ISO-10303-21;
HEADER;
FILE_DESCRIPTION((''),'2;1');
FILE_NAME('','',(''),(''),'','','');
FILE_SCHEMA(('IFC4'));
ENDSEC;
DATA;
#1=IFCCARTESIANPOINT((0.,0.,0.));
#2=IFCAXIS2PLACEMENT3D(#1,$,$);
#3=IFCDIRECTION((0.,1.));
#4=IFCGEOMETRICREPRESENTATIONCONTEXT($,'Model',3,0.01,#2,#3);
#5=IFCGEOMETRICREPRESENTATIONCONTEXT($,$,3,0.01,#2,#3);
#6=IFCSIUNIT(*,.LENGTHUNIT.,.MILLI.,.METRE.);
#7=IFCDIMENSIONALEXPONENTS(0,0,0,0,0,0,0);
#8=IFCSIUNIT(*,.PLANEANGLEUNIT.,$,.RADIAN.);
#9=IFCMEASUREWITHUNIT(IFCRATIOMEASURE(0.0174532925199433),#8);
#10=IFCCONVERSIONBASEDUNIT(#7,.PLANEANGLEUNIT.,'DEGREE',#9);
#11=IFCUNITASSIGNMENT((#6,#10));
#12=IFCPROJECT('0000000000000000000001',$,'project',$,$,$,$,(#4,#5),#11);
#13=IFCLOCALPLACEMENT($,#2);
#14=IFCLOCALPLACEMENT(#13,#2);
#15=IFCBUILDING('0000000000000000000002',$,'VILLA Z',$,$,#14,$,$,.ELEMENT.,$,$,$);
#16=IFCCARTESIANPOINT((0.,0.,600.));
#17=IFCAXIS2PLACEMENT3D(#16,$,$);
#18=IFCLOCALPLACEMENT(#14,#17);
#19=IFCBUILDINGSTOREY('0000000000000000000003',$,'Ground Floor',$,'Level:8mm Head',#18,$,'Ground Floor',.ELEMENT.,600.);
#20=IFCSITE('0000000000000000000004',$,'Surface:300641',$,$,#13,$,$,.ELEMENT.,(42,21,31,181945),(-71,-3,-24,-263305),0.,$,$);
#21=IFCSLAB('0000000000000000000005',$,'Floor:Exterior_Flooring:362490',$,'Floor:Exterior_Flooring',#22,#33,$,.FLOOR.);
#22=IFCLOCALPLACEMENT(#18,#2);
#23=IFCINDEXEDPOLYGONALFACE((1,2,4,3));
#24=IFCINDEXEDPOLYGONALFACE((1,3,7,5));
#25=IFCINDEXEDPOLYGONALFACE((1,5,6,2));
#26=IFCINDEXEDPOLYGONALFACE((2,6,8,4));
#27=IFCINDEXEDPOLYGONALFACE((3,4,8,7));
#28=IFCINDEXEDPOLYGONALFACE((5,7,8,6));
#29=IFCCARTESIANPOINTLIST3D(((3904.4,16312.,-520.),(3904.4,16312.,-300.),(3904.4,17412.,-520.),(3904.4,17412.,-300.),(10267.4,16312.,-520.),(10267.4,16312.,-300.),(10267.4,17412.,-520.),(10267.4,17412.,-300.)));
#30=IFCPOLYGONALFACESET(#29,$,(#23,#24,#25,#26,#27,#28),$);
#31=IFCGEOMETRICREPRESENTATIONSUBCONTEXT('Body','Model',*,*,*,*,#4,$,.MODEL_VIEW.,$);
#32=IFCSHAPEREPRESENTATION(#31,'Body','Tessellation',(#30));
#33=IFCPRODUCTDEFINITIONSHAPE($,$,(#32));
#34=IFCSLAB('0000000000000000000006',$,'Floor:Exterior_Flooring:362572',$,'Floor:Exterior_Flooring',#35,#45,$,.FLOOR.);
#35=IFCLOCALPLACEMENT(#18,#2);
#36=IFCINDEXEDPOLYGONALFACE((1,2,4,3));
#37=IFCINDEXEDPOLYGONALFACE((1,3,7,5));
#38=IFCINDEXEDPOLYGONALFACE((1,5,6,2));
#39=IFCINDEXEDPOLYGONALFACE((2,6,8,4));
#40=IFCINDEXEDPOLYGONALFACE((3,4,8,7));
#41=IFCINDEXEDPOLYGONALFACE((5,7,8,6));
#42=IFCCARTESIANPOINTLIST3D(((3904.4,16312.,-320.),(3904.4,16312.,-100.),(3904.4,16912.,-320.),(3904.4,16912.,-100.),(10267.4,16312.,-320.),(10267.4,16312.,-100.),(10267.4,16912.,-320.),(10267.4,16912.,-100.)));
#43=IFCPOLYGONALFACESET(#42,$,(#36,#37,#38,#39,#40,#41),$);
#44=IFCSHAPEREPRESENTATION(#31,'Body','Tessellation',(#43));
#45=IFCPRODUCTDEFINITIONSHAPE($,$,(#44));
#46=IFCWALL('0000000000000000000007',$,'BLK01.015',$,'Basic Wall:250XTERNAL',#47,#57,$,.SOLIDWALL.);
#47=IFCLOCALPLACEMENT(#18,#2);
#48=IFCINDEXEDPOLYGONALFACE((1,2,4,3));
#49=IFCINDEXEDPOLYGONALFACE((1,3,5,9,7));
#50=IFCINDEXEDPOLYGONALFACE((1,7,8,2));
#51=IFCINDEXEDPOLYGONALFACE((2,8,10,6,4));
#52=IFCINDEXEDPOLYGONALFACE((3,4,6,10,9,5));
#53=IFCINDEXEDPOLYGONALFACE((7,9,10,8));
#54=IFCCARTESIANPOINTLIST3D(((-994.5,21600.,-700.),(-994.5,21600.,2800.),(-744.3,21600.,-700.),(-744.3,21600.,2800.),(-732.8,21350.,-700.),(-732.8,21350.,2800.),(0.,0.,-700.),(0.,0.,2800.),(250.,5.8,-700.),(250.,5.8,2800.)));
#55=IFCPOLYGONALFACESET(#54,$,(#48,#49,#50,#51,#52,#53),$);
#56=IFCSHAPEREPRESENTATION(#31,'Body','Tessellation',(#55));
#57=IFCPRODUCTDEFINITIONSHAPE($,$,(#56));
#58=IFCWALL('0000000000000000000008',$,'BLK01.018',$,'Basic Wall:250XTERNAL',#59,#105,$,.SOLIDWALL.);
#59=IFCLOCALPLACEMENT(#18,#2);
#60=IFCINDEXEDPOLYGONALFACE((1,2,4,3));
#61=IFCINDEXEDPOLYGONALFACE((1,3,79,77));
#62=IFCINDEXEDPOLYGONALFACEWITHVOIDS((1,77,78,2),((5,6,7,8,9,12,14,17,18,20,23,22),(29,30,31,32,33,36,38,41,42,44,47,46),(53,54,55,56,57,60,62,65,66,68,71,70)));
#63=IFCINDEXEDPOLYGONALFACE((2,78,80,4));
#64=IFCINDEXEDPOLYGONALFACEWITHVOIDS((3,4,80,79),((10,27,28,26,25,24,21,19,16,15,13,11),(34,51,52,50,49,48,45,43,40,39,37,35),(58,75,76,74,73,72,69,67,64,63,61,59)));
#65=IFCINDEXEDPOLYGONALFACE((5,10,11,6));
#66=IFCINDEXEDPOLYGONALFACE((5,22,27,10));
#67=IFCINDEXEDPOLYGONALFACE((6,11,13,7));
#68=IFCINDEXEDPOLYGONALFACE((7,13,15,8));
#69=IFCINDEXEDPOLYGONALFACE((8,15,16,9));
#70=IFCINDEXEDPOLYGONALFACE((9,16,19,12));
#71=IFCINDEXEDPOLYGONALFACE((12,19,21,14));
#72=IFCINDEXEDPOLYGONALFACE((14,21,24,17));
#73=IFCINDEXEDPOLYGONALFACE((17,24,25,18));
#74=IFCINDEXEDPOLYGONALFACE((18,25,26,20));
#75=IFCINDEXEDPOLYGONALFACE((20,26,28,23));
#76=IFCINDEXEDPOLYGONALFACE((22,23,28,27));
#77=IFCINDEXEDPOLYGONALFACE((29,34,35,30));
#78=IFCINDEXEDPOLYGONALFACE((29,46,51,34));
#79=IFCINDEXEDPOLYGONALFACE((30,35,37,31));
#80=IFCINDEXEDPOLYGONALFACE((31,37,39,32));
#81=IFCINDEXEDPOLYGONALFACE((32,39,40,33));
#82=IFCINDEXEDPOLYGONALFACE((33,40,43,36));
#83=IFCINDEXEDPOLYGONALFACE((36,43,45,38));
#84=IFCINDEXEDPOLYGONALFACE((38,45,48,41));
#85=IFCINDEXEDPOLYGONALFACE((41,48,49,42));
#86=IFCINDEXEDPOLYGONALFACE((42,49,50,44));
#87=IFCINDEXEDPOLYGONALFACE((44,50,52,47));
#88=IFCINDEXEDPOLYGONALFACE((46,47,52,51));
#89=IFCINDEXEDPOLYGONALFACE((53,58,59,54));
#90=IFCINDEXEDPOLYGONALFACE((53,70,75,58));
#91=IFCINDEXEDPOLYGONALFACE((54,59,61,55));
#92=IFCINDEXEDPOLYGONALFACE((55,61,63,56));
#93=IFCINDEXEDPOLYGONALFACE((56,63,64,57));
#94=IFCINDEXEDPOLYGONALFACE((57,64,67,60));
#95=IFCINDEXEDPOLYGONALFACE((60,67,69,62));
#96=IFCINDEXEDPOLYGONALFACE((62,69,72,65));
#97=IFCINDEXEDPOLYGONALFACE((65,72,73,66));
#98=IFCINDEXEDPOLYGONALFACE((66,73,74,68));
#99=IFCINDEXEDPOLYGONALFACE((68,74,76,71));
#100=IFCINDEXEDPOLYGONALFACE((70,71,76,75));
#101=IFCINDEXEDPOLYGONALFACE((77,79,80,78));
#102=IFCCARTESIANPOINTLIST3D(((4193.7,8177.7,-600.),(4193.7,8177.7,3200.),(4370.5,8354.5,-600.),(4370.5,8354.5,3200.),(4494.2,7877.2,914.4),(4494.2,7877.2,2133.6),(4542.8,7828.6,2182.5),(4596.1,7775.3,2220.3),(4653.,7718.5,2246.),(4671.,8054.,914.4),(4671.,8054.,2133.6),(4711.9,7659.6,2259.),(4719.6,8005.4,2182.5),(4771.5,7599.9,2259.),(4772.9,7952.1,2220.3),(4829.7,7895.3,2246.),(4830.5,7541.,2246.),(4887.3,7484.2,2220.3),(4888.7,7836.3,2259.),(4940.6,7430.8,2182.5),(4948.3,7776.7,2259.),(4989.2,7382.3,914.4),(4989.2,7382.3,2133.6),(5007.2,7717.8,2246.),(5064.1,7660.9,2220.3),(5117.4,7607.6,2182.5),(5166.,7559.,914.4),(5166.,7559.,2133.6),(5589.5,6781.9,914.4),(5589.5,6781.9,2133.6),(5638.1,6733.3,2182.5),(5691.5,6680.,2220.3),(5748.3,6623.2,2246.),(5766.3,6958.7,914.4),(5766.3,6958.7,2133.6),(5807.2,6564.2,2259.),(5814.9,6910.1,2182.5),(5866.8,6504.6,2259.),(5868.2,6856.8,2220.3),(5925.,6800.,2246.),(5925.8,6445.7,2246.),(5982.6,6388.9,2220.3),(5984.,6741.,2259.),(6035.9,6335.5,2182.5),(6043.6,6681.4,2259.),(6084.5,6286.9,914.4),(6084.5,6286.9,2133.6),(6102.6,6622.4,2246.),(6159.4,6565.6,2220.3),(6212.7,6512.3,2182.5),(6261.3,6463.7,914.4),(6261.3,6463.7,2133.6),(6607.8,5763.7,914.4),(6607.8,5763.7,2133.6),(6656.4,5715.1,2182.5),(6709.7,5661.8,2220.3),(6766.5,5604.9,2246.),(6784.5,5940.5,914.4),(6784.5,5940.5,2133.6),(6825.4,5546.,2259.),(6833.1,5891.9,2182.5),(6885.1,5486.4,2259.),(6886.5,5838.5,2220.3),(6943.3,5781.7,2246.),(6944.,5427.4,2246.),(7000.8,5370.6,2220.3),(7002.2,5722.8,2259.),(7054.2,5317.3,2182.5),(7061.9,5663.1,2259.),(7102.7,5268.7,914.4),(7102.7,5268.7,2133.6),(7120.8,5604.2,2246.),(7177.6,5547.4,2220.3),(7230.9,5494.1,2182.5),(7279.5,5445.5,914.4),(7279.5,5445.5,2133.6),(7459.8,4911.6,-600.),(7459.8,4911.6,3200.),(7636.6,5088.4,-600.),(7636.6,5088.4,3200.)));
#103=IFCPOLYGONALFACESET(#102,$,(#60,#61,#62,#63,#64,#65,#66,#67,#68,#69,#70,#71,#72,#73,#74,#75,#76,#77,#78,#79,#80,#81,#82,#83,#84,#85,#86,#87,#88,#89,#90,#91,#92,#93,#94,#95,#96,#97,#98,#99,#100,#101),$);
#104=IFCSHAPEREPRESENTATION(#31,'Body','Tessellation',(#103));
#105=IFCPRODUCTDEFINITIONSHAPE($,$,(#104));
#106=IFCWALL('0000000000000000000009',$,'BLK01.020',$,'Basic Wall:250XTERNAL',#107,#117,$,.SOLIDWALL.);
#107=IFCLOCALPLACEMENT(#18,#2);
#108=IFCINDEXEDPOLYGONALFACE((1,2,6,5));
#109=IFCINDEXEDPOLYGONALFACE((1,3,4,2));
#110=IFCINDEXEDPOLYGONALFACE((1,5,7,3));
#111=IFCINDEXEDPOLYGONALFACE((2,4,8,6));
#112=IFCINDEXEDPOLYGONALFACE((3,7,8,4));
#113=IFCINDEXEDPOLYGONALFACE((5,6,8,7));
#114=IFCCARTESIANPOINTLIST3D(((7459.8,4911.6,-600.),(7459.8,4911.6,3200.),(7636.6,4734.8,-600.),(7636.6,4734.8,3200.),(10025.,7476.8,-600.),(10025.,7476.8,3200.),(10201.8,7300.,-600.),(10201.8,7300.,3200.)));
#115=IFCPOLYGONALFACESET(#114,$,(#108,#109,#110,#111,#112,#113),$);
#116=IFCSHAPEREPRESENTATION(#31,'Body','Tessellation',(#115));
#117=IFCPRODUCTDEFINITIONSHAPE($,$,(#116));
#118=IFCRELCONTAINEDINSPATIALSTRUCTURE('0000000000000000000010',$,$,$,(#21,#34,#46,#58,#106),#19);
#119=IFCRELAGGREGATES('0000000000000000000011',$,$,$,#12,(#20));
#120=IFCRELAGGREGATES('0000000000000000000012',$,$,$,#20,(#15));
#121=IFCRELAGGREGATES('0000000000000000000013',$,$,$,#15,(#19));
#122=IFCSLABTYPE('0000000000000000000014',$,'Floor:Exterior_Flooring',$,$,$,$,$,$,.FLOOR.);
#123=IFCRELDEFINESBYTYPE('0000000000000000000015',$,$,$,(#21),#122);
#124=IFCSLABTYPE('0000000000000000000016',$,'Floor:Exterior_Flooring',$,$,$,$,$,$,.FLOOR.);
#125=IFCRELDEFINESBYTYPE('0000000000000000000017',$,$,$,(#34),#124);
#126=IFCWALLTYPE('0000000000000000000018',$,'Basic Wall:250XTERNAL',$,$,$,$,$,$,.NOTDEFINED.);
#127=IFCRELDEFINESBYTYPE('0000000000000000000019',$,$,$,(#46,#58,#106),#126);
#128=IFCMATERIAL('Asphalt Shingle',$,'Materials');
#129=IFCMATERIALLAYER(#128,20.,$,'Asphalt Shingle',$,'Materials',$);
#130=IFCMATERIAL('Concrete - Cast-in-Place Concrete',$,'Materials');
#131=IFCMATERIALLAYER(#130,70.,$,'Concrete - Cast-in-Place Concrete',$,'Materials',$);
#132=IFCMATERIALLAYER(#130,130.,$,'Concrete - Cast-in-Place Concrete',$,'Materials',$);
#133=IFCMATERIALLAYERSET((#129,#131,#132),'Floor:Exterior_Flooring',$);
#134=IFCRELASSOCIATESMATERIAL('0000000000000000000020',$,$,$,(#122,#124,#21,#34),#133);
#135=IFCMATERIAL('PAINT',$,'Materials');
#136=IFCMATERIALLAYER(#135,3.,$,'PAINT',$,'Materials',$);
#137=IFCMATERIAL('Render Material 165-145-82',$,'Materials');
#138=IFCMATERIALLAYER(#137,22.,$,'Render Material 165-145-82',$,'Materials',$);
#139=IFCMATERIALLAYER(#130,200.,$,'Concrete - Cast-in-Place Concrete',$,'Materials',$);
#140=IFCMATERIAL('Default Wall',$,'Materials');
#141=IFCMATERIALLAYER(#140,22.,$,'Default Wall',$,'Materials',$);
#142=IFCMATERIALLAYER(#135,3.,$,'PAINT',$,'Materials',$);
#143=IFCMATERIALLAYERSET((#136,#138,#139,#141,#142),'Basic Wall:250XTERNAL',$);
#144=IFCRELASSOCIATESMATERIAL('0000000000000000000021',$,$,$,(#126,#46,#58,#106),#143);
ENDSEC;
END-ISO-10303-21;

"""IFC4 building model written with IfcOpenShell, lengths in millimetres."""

from ifc_helpers import new_model, entity, si_unit, converted_unit, direction, frame, frame_2d, origin, origin_2d_with_axis, place, context, subcontext, project, spatial, polyline, circle_curve, parameter, trimmed, segment, composite_curve, rectangle, outline, extrude, clip, halfspace, material, layer, layer_set, layer_usage, type_object, element, save


model = new_model("IFC4")

# Units and contexts
model_context = context("Model", 3, precision=0.01, world=origin(), true_north=direction((0.0, 1.0)))
context_of_model = context(None, 3, precision=0.01, world=origin(), true_north=direction((0.0, 1.0)))
body_context = subcontext(model_context, "Body", "Model", "MODEL_VIEW")
ifc_project = project(units=[si_unit("LENGTHUNIT", "METRE", prefix="MILLI"), converted_unit("PLANEANGLEUNIT", "DEGREE", entity("IfcRatioMeasure", 0.0174532925199433), si_unit("PLANEANGLEUNIT", "RADIAN"), dimensions=[0, 0, 0, 0, 0, 0, 0])], contexts=[model_context, context_of_model])

# Site, building, storey
site_placement = place(None, origin())
site = spatial("IfcSite", under=ifc_project, at=site_placement, Name="Surface:300641", CompositionType="ELEMENT", RefLatitude=(42, 21, 31, 181945), RefLongitude=(-71, -3, -24, -263305), RefElevation=0.0)
building_placement = place(site_placement, origin())
building = spatial("IfcBuilding", under=site, at=building_placement, Name="VILLA Z", CompositionType="ELEMENT")
storey_placement = place(building_placement, frame((0.0, 0.0, 600.0)))
storey = spatial("IfcBuildingStorey", under=building, at=storey_placement, Name="Ground Floor", ObjectType="Level:8mm Head", LongName="Ground Floor", CompositionType="ELEMENT", Elevation=600.0)

# Shared definitions
ifc_material_1 = material(Name="Concrete - Cast-in-Place Concrete", Category="Materials")

# Slabs
ifc_material_2 = material(Name="Asphalt Shingle", Category="Materials")
ifc_layer_1 = layer(ifc_material_2, 20.0, Name="Asphalt Shingle", Category="Materials")
ifc_layer_2 = layer(ifc_material_1, 70.0, Name="Concrete - Cast-in-Place Concrete", Category="Materials")
ifc_layer_3 = layer(ifc_material_1, 130.0, Name="Concrete - Cast-in-Place Concrete", Category="Materials")
ifc_layer_set_1 = layer_set([ifc_layer_1, ifc_layer_2, ifc_layer_3], Name="Floor:Exterior_Flooring")
ifc_layer_usage_1 = layer_usage(ifc_layer_set_1, "AXIS3", "POSITIVE", 0.0)
slab_type_1 = type_object("IfcSlabType", Name="Floor:Exterior_Flooring", PredefinedType="FLOOR", material=ifc_layer_set_1)
slab_1_placement = place(storey_placement, origin())
element("IfcSlab", 1, at=slab_1_placement, inside=storey, type_object=slab_type_1, material=ifc_layer_usage_1, Name="Floor:Exterior_Flooring:362490", ObjectType="Floor:Exterior_Flooring", PredefinedType="FLOOR", context=body_context, shape_type="SweptSolid", body=[
    extrude(rectangle(XDim=1100.0, YDim=6362.9, at=origin_2d_with_axis()), frame((7085.9, 16862.0, -300.0), z_axis=(0.0, 0.0, -1.0), x_axis=(0.0, 1.0, 0.0)), (0.0, 0.0, 1.0), 220.0),
])
ifc_layer_usage_2 = layer_usage(ifc_layer_set_1, "AXIS3", "POSITIVE", 0.0)
slab_type_2 = type_object("IfcSlabType", Name="Floor:Exterior_Flooring", PredefinedType="FLOOR", material=ifc_layer_set_1)
slab_2_placement = place(storey_placement, origin())
element("IfcSlab", 2, at=slab_2_placement, inside=storey, type_object=slab_type_2, material=ifc_layer_usage_2, Name="Floor:Exterior_Flooring:362572", ObjectType="Floor:Exterior_Flooring", PredefinedType="FLOOR", context=body_context, shape_type="SweptSolid", body=[
    extrude(rectangle(XDim=600.0, YDim=6362.9, at=frame_2d((0.0, 0.0), x_axis=(1.0, 0.0))), frame((7085.9, 16612.0, -100.0), z_axis=(0.0, 0.0, -1.0), x_axis=(0.0, 1.0, 0.0)), (0.0, 0.0, 1.0), 220.0),
])

# Wall
ifc_material_3 = material(Name="PAINT", Category="Materials")
ifc_layer_4 = layer(ifc_material_3, 3.0, Name="PAINT", Category="Materials")
ifc_material_4 = material(Name="Render Material 165-145-82", Category="Materials")
ifc_layer_5 = layer(ifc_material_4, 22.0, Name="Render Material 165-145-82", Category="Materials")
ifc_layer_6 = layer(ifc_material_1, 200.0, Name="Concrete - Cast-in-Place Concrete", Category="Materials")
ifc_material_5 = material(Name="Default Wall", Category="Materials")
ifc_layer_7 = layer(ifc_material_5, 22.0, Name="Default Wall", Category="Materials")
ifc_layer_8 = layer(ifc_material_3, 3.0, Name="PAINT", Category="Materials")
ifc_layer_set_2 = layer_set([ifc_layer_4, ifc_layer_5, ifc_layer_6, ifc_layer_7, ifc_layer_8], Name="Basic Wall:250XTERNAL")
ifc_layer_usage_3 = layer_usage(ifc_layer_set_2, "AXIS2", "NEGATIVE", 125.0)
wall_type_1 = type_object("IfcWallType", Name="Basic Wall:250XTERNAL", PredefinedType="NOTDEFINED", material=ifc_layer_set_2)
wall_1_placement = place(storey_placement, frame((125.1, 0.0, -700.0), z_axis=(0.0, 0.0, 1.0), x_axis=(-0.045995, 0.998942, 0.0)))
element("IfcWall", 3, at=wall_1_placement, inside=storey, type_object=wall_type_1, material=ifc_layer_usage_3, Name="BLK01.015", ObjectType="Basic Wall:250XTERNAL", PredefinedType="SOLIDWALL", context=body_context, shape_type="SweptSolid", body=[
    extrude(outline(polyline([(21617.1, -125.0), (21628.6, 125.0), (5.8, 125.0), (0.0, -125.0), (21366.9, -125.0), (21617.1, -125.0)])), origin(), (0.0, 0.0, 1.0), 3500.0),
])

# Wall, openings
ifc_layer_usage_4 = layer_usage(ifc_layer_set_2, "AXIS2", "NEGATIVE", 125.0)
wall_2_placement = place(storey_placement, frame((7548.2, 5000.0, -600.0), z_axis=(0.0, 0.0, 1.0), x_axis=(-0.707107, 0.707107, 0.0)))
wall_2 = element("IfcWall", 4, at=wall_2_placement, inside=storey, type_object=wall_type_1, material=ifc_layer_usage_4, Name="BLK01.018", ObjectType="Basic Wall:250XTERNAL", PredefinedType="SOLIDWALL", context=body_context, shape_type="Clipping", body=[
    clip(extrude(rectangle(XDim=4619.0, YDim=250.0, at=frame_2d((2309.5, 0.0), x_axis=(-1.0, 0.0))), origin(), (0.0, 0.0, 1.0), 3800.0), halfspace(frame((0.0, 0.0, -600.0)), True)),
])
opening_1_placement = place(wall_2_placement, frame((1205.0, 125.0, 1514.4)))
element("IfcOpeningElement", 5, at=opening_1_placement, cuts=wall_2, ObjectType="Opening", PredefinedType="OPENING", context=body_context, shape_type="SweptSolid", body=[
    extrude(outline(composite_curve([segment(polyline([(0.0, 0.0), (1219.2, 0.0)]), True, "CONTINUOUS"), segment(trimmed(circle_curve(frame_2d((800.4, 350.0), x_axis=(0.0, 1.0)), 545.8), [parameter(230.112671)], [parameter(309.887329)], True, "PARAMETER"), True, "CONTINUOUS"), segment(polyline([(1219.2, 700.0), (0.0, 700.0)]), True, "CONTINUOUS"), segment(polyline([(0.0, 700.0), (0.0, 0.0)]), True, "CONTINUOUS")], self_intersect=False)), frame((0.0, 0.0, 0.0), z_axis=(0.0, -1.0, 0.0), x_axis=(0.0, 0.0, 1.0)), (0.0, 0.0, 1.0), 250.0),
])
opening_2_placement = place(wall_2_placement, frame((2645.0, 125.0, 1514.4)))
element("IfcOpeningElement", 6, at=opening_2_placement, cuts=wall_2, ObjectType="Opening", PredefinedType="OPENING", context=body_context, shape_type="SweptSolid", body=[
    extrude(outline(composite_curve([segment(polyline([(0.0, 0.0), (1219.2, 0.0)]), True, "CONTINUOUS"), segment(trimmed(circle_curve(frame_2d((800.4, 350.0), x_axis=(0.0, 1.0)), 545.8), [parameter(230.112671)], [parameter(309.887329)], True, "PARAMETER"), True, "CONTINUOUS"), segment(polyline([(1219.2, 700.0), (0.0, 700.0)]), True, "CONTINUOUS"), segment(polyline([(0.0, 700.0), (0.0, 0.0)]), True, "CONTINUOUS")], self_intersect=False)), frame((0.0, 0.0, 0.0), z_axis=(0.0, -1.0, 0.0), x_axis=(0.0, 0.0, 1.0)), (0.0, 0.0, 1.0), 250.0),
])
opening_3_placement = place(wall_2_placement, frame((4194.0, 125.0, 1514.4)))
element("IfcOpeningElement", 7, at=opening_3_placement, cuts=wall_2, ObjectType="Opening", PredefinedType="OPENING", context=body_context, shape_type="SweptSolid", body=[
    extrude(outline(composite_curve([segment(polyline([(0.0, 0.0), (1219.2, 0.0)]), True, "CONTINUOUS"), segment(trimmed(circle_curve(frame_2d((800.4, 350.0), x_axis=(0.0, 1.0)), 545.8), [parameter(230.112671)], [parameter(309.887329)], True, "PARAMETER"), True, "CONTINUOUS"), segment(polyline([(1219.2, 700.0), (0.0, 700.0)]), True, "CONTINUOUS"), segment(polyline([(0.0, 700.0), (0.0, 0.0)]), True, "CONTINUOUS")], self_intersect=False)), frame((0.0, 0.0, 0.0), z_axis=(0.0, -1.0, 0.0), x_axis=(0.0, 0.0, 1.0)), (0.0, 0.0, 1.0), 250.0),
])

# Wall
ifc_layer_usage_5 = layer_usage(ifc_layer_set_2, "AXIS2", "NEGATIVE", 125.0)
wall_3_placement = place(storey_placement, frame((7548.2, 4823.2, -600.0), z_axis=(0.0, 0.0, 1.0), x_axis=(0.707107, 0.707107, 0.0)))
element("IfcWall", 8, at=wall_3_placement, inside=storey, type_object=wall_type_1, material=ifc_layer_usage_5, Name="BLK01.020", ObjectType="Basic Wall:250XTERNAL", PredefinedType="SOLIDWALL", context=body_context, shape_type="Clipping", body=[
    clip(extrude(rectangle(XDim=3627.7, YDim=250.0, at=frame_2d((1813.8, 0.0), x_axis=(-1.0, 0.0))), origin(), (0.0, 0.0, 1.0), 3800.0), halfspace(frame((0.0, 0.0, -600.0)), True)),
])

save(model, "model.ifc")
